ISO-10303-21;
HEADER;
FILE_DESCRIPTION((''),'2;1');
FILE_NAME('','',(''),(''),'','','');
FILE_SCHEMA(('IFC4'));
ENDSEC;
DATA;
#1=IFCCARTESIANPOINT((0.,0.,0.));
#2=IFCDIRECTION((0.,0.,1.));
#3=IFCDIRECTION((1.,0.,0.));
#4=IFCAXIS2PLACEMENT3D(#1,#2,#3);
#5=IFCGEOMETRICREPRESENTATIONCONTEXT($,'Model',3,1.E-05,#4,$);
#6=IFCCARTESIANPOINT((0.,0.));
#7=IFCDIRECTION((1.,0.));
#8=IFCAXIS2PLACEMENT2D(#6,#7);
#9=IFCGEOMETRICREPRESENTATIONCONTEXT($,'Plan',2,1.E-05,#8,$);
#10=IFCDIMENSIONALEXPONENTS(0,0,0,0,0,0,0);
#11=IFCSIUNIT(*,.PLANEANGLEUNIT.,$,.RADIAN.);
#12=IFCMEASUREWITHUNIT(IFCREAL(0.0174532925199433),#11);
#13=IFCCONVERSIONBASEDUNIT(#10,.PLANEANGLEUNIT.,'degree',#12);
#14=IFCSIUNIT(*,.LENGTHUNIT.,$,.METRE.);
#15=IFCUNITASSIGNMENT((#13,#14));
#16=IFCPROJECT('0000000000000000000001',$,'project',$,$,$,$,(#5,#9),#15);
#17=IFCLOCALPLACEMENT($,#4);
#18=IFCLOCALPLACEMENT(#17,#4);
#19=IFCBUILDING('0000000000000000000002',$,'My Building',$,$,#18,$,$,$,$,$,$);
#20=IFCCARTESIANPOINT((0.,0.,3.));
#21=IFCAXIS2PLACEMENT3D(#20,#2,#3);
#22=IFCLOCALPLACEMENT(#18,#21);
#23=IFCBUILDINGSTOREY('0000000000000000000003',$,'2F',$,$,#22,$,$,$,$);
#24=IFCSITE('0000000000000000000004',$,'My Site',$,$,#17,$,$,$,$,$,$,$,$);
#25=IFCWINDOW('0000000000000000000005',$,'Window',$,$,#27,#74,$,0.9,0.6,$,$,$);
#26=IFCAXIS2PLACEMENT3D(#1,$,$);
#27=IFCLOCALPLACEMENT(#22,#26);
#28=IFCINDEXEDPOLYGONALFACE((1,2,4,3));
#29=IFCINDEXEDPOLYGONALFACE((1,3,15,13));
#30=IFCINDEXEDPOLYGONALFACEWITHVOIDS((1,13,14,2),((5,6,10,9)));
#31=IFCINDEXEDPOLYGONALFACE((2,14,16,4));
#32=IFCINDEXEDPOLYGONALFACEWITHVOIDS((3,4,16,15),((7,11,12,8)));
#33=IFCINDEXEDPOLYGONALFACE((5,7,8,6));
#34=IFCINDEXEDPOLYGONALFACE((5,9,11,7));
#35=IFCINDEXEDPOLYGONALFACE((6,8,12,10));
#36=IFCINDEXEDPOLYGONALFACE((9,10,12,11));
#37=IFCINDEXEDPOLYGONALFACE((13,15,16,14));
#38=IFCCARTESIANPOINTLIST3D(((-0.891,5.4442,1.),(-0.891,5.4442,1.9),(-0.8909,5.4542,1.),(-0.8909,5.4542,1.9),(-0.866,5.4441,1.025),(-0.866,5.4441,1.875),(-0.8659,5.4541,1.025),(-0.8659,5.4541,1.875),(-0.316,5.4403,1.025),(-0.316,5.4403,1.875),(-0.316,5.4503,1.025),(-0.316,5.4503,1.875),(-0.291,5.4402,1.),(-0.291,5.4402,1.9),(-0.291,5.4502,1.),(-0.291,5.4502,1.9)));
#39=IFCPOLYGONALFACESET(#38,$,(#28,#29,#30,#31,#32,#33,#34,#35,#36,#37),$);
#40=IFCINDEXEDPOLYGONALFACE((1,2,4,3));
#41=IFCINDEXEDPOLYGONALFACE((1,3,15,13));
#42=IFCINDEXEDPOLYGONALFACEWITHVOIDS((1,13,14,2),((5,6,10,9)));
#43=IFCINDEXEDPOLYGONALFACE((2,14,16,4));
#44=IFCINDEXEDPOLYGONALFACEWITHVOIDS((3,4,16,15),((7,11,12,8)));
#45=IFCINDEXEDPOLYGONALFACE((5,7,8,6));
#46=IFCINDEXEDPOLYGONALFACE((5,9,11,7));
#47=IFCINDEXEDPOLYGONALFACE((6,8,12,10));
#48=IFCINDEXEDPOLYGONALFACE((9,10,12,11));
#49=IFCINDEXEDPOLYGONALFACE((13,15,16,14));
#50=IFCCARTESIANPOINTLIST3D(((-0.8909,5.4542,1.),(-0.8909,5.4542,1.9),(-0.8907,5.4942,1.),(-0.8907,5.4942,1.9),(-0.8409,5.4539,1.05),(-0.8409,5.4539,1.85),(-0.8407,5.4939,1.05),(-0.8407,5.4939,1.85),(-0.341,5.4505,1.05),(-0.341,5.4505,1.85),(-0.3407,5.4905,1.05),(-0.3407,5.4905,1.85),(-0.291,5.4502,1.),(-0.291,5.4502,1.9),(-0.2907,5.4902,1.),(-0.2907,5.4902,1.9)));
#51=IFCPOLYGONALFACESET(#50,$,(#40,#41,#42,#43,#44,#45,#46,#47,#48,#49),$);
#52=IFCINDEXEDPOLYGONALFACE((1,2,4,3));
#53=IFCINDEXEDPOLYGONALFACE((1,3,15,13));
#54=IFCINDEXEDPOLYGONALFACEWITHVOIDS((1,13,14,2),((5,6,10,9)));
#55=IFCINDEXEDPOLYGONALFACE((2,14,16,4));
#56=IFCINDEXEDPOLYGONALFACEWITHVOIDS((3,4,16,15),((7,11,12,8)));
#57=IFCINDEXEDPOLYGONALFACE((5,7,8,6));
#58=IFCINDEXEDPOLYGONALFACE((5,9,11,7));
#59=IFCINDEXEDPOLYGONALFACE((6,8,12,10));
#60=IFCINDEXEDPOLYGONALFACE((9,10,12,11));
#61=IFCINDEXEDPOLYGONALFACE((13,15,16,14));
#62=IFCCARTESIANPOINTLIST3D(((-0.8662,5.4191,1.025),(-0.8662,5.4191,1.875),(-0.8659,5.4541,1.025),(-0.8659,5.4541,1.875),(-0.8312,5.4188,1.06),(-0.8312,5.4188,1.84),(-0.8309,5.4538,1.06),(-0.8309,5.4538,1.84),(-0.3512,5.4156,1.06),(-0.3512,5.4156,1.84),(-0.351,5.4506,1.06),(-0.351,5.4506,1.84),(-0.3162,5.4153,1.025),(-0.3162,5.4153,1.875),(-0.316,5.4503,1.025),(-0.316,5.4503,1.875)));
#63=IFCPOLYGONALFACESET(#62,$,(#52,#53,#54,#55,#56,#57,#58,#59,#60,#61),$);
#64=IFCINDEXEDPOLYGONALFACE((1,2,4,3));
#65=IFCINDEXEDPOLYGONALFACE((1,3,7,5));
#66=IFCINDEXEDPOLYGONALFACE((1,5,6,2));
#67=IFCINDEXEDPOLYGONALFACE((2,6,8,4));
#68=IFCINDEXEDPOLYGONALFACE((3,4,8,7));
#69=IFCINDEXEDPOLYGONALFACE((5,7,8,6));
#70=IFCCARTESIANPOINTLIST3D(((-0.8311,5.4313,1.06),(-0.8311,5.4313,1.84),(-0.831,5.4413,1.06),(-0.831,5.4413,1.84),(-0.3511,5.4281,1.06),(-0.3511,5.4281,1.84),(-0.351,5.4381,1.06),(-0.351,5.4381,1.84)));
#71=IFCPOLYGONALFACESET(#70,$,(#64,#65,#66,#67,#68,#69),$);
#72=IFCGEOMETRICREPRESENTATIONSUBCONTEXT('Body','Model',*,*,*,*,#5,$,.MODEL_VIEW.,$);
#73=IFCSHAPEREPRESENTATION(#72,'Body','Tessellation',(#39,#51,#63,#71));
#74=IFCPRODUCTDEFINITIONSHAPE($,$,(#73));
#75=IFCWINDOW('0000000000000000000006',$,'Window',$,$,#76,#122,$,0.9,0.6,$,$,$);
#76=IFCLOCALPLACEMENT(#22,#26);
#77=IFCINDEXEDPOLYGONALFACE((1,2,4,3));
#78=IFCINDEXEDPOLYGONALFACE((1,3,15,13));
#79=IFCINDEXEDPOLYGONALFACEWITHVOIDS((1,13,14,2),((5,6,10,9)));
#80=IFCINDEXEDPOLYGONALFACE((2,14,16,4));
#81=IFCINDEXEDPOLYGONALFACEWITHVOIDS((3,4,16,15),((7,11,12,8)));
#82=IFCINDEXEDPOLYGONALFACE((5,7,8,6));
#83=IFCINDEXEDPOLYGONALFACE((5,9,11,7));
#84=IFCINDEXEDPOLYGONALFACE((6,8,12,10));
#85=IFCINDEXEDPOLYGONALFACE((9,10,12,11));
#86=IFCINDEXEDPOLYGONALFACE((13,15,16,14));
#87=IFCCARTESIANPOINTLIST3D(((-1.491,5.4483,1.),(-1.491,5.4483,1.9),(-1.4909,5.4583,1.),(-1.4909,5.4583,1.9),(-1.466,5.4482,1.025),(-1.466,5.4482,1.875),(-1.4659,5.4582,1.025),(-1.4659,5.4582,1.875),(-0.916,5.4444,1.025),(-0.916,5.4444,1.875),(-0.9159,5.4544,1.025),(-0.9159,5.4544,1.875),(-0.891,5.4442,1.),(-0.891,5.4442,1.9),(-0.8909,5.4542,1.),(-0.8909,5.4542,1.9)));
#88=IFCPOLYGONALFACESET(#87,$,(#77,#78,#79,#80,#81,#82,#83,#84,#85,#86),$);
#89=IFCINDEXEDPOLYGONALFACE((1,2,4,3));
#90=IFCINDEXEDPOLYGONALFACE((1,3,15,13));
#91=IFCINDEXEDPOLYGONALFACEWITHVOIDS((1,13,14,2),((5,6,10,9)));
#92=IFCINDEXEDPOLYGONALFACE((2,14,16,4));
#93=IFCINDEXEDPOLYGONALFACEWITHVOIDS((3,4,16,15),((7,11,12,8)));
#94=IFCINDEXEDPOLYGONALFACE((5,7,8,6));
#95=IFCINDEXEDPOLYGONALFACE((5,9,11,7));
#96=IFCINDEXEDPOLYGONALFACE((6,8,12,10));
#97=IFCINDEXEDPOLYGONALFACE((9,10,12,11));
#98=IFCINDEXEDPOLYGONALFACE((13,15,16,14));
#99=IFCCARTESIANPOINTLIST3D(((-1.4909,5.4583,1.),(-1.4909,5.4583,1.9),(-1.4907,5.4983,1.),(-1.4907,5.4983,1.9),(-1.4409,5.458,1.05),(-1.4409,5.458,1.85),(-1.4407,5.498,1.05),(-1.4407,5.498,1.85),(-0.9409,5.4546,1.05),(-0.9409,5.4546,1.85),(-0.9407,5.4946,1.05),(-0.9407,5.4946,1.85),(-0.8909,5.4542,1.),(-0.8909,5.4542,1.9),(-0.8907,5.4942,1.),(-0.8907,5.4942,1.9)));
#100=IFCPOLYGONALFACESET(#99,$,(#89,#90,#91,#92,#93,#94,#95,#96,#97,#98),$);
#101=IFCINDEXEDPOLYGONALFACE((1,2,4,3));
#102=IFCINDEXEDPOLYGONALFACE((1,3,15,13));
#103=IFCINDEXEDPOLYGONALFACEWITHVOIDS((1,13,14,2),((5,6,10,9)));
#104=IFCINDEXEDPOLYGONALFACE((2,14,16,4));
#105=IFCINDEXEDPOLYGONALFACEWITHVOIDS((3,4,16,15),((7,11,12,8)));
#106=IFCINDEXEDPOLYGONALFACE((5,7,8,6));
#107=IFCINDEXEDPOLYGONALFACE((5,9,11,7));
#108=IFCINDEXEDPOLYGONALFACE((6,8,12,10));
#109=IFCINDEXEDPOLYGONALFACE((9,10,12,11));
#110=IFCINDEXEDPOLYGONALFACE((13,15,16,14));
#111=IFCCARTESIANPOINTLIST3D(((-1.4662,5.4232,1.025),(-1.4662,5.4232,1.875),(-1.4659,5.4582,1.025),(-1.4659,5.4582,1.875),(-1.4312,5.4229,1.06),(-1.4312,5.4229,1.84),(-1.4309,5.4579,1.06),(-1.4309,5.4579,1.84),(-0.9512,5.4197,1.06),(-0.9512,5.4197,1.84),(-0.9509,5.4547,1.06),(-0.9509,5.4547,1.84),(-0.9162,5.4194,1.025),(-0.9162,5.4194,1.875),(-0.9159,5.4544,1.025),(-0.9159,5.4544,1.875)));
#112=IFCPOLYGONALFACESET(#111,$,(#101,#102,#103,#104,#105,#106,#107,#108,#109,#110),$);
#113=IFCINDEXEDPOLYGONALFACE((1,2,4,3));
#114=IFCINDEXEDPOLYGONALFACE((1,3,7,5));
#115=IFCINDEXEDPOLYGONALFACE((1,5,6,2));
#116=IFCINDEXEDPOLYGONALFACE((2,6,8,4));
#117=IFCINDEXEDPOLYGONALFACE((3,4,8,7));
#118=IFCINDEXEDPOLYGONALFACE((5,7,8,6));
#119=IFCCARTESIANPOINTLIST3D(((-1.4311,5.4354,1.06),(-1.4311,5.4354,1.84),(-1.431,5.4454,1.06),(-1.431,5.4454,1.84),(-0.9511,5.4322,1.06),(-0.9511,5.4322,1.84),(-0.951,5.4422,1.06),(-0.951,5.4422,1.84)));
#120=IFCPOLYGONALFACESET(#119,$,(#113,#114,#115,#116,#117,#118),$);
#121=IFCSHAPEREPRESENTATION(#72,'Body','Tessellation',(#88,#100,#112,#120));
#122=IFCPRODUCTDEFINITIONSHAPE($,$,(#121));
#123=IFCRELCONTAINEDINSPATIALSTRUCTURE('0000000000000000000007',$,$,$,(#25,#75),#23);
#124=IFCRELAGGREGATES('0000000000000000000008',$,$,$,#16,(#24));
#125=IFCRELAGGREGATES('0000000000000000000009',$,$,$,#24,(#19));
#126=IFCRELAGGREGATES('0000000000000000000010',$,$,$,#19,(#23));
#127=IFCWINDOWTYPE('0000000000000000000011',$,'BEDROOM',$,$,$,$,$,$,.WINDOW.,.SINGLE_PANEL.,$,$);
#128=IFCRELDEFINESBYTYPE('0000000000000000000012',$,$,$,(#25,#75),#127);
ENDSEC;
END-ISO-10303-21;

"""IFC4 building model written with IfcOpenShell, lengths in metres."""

from ifc_helpers import new_model, entity, si_unit, converted_unit, frame, origin_with_axes, origin_2d_with_axis, place, context, subcontext, project, spatial, line, indexed_curve, outline, extrude, shape, source, transform, mapped, type_object, type_shapes, element, save


model = new_model("IFC4")

# Units and contexts
model_context = context("Model", 3, precision=1e-05, world=origin_with_axes())
plan_context = context("Plan", 2, precision=1e-05, world=origin_2d_with_axis())
body_context_1 = subcontext(model_context, "Body", "Model", "MODEL_VIEW")
body_context_2 = subcontext(plan_context, "Body", "Plan", "PLAN_VIEW")
ifc_project = project(units=[converted_unit("PLANEANGLEUNIT", "degree", entity("IfcReal", 0.0174532925199433), si_unit("PLANEANGLEUNIT", "RADIAN"), dimensions=[0, 0, 0, 0, 0, 0, 0]), si_unit("LENGTHUNIT", "METRE")], contexts=[model_context, plan_context])

# Site, building, storey
site_placement = place(None, origin_with_axes())
site = spatial("IfcSite", under=ifc_project, at=site_placement, Name="My Site")
building_placement = place(site_placement, origin_with_axes())
building = spatial("IfcBuilding", under=site, at=building_placement, Name="My Building")
storey_placement = place(building_placement, frame((0.0, 0.0, 3.0), z_axis=(0.0, 0.0, 1.0), x_axis=(1.0, 0.0, 0.0)))
storey = spatial("IfcBuildingStorey", under=building, at=storey_placement, Name="2F")

# Shared definitions
window_type_1 = type_object("IfcWindowType", Name="BEDROOM", PartitioningType="SINGLE_PANEL", PredefinedType="WINDOW")
shared_shape_1 = source(origin_with_axes(), body_context_1, "Body", "SweptSolid", [
    extrude(outline(indexed_curve([(0.0, 0.0), (0.6, 0.0), (0.6, 0.9), (0.0, 0.9)], segments=[line(1, 2, 3, 4, 1)]), holes=[indexed_curve([(0.025, 0.025), (0.575, 0.025), (0.575, 0.875), (0.025, 0.875)], segments=[line(1, 2, 3, 4, 1)])]), frame((0.0, 0.09, 0.0), z_axis=(0.0, -1.0, 0.0), x_axis=(1.0, 0.0, 0.0)), (0.0, 0.0, -1.0), 0.01),
    extrude(outline(indexed_curve([(0.0, 0.0), (0.6, 0.0), (0.6, 0.9), (0.0, 0.9)], segments=[line(1, 2, 3, 4, 1)]), holes=[indexed_curve([(0.05, 0.05), (0.55, 0.05), (0.55, 0.85), (0.05, 0.85)], segments=[line(1, 2, 3, 4, 1)])]), frame((0.0, 0.05, 0.0), z_axis=(0.0, -1.0, 0.0), x_axis=(1.0, 0.0, 0.0)), (0.0, 0.0, -1.0), 0.04),
    extrude(outline(indexed_curve([(0.0, 0.0), (0.55, 0.0), (0.55, 0.85), (0.0, 0.85)], segments=[line(1, 2, 3, 4, 1)]), holes=[indexed_curve([(0.035, 0.035), (0.515, 0.035), (0.515, 0.815), (0.035, 0.815)], segments=[line(1, 2, 3, 4, 1)])]), frame((0.025, 0.09, 0.025), z_axis=(0.0, -1.0, 0.0), x_axis=(1.0, 0.0, 0.0)), (0.0, 0.0, -1.0), 0.035),
    extrude(outline(indexed_curve([(0.035, 0.035), (0.515, 0.035), (0.515, 0.815), (0.035, 0.815)], segments=[line(1, 2, 3, 4, 1)])), frame((0.025, 0.1025, 0.025), z_axis=(0.0, -1.0, 0.0), x_axis=(1.0, 0.0, 0.0)), (0.0, 0.0, -1.0), 0.01),
])
shared_shape_2 = source(origin_with_axes(), body_context_2, "Body", "Curve2D", [
    entity("IfcIndexedPolyCurve", entity("IfcCartesianPointList2D", [[0.05, 0.05], [0.55, 0.05]])),
    entity("IfcIndexedPolyCurve", entity("IfcCartesianPointList2D", [[0.0, 0.1], [0.025, 0.1], [0.025, 0.09], [0.05, 0.09], [0.05, 0.05], [0.0, 0.05]]), [entity("IfcLineIndex", [1, 2, 3, 4, 5, 6, 1])]),
    entity("IfcIndexedPolyCurve", entity("IfcCartesianPointList2D", [[0.6, 0.1], [0.575, 0.1], [0.575, 0.09], [0.55, 0.09], [0.55, 0.05], [0.6, 0.05]]), [entity("IfcLineIndex", [1, 2, 3, 4, 5, 6, 1])]),
    entity("IfcIndexedPolyCurve", entity("IfcCartesianPointList2D", [[0.025, 0.09], [0.06, 0.09], [0.06, 0.125], [0.025, 0.125]]), [entity("IfcLineIndex", [1, 2, 3, 4, 1])]),
    entity("IfcIndexedPolyCurve", entity("IfcCartesianPointList2D", [[0.575, 0.09], [0.54, 0.09], [0.54, 0.125], [0.575, 0.125]]), [entity("IfcLineIndex", [1, 2, 3, 4, 1])]),
    entity("IfcIndexedPolyCurve", entity("IfcCartesianPointList2D", [[0.06, 0.09], [0.54, 0.09]])),
    entity("IfcIndexedPolyCurve", entity("IfcCartesianPointList2D", [[0.06, 0.125], [0.54, 0.125]])),
    entity("IfcIndexedPolyCurve", entity("IfcCartesianPointList2D", [[0.06, 0.1075], [0.54, 0.1075]])),
])
type_shapes(window_type_1, [shared_shape_1, shared_shape_2])

# Windows
placement_1 = place(storey_placement, frame((0.2053, 5.5368, 0.0), z_axis=(0.0, 0.0, 1.0), x_axis=(-0.999977, 0.006815, 0.0)))
placement_2 = place(placement_1, frame((0.4957, 0.0, 1.0), z_axis=(0.0, 0.0, 1.0), x_axis=(1.0, 0.0, 0.0)))
window_1_placement = place(placement_2, frame((0.0, 0.0, 0.0), z_axis=(0.0, 0.0, 1.0), x_axis=(1.0, 0.0, 0.0)))
element("IfcWindow", 1, at=window_1_placement, inside=storey, type_object=window_type_1, Name="Window", OverallHeight=0.9, OverallWidth=0.6, shapes=[
    shape(body_context_1, "Body", "MappedRepresentation", [mapped(shared_shape_1, transform((0.0, 0.0, 0.0), x_axis=(1.0, 0.0, 0.0), y_axis=(0.0, 1.0, 0.0), z_axis=(0.0, 0.0, 1.0), scale=1.0))]),
    shape(body_context_2, "Body", "MappedRepresentation", [mapped(shared_shape_2, transform((0.0, 0.0, 0.0), x_axis=(1.0, 0.0, 0.0), y_axis=(0.0, 1.0, 0.0), z_axis=(0.0, 0.0, 1.0), scale=1.0))]),
])
placement_3 = place(placement_1, frame((1.0957, 0.0, 1.0), z_axis=(0.0, 0.0, 1.0), x_axis=(1.0, 0.0, 0.0)))
window_2_placement = place(placement_3, frame((0.0, 0.0, 0.0), z_axis=(0.0, 0.0, 1.0), x_axis=(1.0, 0.0, 0.0)))
element("IfcWindow", 2, at=window_2_placement, inside=storey, type_object=window_type_1, Name="Window", OverallHeight=0.9, OverallWidth=0.6, shapes=[
    shape(body_context_1, "Body", "MappedRepresentation", [mapped(shared_shape_1, transform((0.0, 0.0, 0.0), x_axis=(1.0, 0.0, 0.0), y_axis=(0.0, 1.0, 0.0), z_axis=(0.0, 0.0, 1.0), scale=1.0))]),
    shape(body_context_2, "Body", "MappedRepresentation", [mapped(shared_shape_2, transform((0.0, 0.0, 0.0), x_axis=(1.0, 0.0, 0.0), y_axis=(0.0, 1.0, 0.0), z_axis=(0.0, 0.0, 1.0), scale=1.0))]),
])

save(model, "model.ifc")
